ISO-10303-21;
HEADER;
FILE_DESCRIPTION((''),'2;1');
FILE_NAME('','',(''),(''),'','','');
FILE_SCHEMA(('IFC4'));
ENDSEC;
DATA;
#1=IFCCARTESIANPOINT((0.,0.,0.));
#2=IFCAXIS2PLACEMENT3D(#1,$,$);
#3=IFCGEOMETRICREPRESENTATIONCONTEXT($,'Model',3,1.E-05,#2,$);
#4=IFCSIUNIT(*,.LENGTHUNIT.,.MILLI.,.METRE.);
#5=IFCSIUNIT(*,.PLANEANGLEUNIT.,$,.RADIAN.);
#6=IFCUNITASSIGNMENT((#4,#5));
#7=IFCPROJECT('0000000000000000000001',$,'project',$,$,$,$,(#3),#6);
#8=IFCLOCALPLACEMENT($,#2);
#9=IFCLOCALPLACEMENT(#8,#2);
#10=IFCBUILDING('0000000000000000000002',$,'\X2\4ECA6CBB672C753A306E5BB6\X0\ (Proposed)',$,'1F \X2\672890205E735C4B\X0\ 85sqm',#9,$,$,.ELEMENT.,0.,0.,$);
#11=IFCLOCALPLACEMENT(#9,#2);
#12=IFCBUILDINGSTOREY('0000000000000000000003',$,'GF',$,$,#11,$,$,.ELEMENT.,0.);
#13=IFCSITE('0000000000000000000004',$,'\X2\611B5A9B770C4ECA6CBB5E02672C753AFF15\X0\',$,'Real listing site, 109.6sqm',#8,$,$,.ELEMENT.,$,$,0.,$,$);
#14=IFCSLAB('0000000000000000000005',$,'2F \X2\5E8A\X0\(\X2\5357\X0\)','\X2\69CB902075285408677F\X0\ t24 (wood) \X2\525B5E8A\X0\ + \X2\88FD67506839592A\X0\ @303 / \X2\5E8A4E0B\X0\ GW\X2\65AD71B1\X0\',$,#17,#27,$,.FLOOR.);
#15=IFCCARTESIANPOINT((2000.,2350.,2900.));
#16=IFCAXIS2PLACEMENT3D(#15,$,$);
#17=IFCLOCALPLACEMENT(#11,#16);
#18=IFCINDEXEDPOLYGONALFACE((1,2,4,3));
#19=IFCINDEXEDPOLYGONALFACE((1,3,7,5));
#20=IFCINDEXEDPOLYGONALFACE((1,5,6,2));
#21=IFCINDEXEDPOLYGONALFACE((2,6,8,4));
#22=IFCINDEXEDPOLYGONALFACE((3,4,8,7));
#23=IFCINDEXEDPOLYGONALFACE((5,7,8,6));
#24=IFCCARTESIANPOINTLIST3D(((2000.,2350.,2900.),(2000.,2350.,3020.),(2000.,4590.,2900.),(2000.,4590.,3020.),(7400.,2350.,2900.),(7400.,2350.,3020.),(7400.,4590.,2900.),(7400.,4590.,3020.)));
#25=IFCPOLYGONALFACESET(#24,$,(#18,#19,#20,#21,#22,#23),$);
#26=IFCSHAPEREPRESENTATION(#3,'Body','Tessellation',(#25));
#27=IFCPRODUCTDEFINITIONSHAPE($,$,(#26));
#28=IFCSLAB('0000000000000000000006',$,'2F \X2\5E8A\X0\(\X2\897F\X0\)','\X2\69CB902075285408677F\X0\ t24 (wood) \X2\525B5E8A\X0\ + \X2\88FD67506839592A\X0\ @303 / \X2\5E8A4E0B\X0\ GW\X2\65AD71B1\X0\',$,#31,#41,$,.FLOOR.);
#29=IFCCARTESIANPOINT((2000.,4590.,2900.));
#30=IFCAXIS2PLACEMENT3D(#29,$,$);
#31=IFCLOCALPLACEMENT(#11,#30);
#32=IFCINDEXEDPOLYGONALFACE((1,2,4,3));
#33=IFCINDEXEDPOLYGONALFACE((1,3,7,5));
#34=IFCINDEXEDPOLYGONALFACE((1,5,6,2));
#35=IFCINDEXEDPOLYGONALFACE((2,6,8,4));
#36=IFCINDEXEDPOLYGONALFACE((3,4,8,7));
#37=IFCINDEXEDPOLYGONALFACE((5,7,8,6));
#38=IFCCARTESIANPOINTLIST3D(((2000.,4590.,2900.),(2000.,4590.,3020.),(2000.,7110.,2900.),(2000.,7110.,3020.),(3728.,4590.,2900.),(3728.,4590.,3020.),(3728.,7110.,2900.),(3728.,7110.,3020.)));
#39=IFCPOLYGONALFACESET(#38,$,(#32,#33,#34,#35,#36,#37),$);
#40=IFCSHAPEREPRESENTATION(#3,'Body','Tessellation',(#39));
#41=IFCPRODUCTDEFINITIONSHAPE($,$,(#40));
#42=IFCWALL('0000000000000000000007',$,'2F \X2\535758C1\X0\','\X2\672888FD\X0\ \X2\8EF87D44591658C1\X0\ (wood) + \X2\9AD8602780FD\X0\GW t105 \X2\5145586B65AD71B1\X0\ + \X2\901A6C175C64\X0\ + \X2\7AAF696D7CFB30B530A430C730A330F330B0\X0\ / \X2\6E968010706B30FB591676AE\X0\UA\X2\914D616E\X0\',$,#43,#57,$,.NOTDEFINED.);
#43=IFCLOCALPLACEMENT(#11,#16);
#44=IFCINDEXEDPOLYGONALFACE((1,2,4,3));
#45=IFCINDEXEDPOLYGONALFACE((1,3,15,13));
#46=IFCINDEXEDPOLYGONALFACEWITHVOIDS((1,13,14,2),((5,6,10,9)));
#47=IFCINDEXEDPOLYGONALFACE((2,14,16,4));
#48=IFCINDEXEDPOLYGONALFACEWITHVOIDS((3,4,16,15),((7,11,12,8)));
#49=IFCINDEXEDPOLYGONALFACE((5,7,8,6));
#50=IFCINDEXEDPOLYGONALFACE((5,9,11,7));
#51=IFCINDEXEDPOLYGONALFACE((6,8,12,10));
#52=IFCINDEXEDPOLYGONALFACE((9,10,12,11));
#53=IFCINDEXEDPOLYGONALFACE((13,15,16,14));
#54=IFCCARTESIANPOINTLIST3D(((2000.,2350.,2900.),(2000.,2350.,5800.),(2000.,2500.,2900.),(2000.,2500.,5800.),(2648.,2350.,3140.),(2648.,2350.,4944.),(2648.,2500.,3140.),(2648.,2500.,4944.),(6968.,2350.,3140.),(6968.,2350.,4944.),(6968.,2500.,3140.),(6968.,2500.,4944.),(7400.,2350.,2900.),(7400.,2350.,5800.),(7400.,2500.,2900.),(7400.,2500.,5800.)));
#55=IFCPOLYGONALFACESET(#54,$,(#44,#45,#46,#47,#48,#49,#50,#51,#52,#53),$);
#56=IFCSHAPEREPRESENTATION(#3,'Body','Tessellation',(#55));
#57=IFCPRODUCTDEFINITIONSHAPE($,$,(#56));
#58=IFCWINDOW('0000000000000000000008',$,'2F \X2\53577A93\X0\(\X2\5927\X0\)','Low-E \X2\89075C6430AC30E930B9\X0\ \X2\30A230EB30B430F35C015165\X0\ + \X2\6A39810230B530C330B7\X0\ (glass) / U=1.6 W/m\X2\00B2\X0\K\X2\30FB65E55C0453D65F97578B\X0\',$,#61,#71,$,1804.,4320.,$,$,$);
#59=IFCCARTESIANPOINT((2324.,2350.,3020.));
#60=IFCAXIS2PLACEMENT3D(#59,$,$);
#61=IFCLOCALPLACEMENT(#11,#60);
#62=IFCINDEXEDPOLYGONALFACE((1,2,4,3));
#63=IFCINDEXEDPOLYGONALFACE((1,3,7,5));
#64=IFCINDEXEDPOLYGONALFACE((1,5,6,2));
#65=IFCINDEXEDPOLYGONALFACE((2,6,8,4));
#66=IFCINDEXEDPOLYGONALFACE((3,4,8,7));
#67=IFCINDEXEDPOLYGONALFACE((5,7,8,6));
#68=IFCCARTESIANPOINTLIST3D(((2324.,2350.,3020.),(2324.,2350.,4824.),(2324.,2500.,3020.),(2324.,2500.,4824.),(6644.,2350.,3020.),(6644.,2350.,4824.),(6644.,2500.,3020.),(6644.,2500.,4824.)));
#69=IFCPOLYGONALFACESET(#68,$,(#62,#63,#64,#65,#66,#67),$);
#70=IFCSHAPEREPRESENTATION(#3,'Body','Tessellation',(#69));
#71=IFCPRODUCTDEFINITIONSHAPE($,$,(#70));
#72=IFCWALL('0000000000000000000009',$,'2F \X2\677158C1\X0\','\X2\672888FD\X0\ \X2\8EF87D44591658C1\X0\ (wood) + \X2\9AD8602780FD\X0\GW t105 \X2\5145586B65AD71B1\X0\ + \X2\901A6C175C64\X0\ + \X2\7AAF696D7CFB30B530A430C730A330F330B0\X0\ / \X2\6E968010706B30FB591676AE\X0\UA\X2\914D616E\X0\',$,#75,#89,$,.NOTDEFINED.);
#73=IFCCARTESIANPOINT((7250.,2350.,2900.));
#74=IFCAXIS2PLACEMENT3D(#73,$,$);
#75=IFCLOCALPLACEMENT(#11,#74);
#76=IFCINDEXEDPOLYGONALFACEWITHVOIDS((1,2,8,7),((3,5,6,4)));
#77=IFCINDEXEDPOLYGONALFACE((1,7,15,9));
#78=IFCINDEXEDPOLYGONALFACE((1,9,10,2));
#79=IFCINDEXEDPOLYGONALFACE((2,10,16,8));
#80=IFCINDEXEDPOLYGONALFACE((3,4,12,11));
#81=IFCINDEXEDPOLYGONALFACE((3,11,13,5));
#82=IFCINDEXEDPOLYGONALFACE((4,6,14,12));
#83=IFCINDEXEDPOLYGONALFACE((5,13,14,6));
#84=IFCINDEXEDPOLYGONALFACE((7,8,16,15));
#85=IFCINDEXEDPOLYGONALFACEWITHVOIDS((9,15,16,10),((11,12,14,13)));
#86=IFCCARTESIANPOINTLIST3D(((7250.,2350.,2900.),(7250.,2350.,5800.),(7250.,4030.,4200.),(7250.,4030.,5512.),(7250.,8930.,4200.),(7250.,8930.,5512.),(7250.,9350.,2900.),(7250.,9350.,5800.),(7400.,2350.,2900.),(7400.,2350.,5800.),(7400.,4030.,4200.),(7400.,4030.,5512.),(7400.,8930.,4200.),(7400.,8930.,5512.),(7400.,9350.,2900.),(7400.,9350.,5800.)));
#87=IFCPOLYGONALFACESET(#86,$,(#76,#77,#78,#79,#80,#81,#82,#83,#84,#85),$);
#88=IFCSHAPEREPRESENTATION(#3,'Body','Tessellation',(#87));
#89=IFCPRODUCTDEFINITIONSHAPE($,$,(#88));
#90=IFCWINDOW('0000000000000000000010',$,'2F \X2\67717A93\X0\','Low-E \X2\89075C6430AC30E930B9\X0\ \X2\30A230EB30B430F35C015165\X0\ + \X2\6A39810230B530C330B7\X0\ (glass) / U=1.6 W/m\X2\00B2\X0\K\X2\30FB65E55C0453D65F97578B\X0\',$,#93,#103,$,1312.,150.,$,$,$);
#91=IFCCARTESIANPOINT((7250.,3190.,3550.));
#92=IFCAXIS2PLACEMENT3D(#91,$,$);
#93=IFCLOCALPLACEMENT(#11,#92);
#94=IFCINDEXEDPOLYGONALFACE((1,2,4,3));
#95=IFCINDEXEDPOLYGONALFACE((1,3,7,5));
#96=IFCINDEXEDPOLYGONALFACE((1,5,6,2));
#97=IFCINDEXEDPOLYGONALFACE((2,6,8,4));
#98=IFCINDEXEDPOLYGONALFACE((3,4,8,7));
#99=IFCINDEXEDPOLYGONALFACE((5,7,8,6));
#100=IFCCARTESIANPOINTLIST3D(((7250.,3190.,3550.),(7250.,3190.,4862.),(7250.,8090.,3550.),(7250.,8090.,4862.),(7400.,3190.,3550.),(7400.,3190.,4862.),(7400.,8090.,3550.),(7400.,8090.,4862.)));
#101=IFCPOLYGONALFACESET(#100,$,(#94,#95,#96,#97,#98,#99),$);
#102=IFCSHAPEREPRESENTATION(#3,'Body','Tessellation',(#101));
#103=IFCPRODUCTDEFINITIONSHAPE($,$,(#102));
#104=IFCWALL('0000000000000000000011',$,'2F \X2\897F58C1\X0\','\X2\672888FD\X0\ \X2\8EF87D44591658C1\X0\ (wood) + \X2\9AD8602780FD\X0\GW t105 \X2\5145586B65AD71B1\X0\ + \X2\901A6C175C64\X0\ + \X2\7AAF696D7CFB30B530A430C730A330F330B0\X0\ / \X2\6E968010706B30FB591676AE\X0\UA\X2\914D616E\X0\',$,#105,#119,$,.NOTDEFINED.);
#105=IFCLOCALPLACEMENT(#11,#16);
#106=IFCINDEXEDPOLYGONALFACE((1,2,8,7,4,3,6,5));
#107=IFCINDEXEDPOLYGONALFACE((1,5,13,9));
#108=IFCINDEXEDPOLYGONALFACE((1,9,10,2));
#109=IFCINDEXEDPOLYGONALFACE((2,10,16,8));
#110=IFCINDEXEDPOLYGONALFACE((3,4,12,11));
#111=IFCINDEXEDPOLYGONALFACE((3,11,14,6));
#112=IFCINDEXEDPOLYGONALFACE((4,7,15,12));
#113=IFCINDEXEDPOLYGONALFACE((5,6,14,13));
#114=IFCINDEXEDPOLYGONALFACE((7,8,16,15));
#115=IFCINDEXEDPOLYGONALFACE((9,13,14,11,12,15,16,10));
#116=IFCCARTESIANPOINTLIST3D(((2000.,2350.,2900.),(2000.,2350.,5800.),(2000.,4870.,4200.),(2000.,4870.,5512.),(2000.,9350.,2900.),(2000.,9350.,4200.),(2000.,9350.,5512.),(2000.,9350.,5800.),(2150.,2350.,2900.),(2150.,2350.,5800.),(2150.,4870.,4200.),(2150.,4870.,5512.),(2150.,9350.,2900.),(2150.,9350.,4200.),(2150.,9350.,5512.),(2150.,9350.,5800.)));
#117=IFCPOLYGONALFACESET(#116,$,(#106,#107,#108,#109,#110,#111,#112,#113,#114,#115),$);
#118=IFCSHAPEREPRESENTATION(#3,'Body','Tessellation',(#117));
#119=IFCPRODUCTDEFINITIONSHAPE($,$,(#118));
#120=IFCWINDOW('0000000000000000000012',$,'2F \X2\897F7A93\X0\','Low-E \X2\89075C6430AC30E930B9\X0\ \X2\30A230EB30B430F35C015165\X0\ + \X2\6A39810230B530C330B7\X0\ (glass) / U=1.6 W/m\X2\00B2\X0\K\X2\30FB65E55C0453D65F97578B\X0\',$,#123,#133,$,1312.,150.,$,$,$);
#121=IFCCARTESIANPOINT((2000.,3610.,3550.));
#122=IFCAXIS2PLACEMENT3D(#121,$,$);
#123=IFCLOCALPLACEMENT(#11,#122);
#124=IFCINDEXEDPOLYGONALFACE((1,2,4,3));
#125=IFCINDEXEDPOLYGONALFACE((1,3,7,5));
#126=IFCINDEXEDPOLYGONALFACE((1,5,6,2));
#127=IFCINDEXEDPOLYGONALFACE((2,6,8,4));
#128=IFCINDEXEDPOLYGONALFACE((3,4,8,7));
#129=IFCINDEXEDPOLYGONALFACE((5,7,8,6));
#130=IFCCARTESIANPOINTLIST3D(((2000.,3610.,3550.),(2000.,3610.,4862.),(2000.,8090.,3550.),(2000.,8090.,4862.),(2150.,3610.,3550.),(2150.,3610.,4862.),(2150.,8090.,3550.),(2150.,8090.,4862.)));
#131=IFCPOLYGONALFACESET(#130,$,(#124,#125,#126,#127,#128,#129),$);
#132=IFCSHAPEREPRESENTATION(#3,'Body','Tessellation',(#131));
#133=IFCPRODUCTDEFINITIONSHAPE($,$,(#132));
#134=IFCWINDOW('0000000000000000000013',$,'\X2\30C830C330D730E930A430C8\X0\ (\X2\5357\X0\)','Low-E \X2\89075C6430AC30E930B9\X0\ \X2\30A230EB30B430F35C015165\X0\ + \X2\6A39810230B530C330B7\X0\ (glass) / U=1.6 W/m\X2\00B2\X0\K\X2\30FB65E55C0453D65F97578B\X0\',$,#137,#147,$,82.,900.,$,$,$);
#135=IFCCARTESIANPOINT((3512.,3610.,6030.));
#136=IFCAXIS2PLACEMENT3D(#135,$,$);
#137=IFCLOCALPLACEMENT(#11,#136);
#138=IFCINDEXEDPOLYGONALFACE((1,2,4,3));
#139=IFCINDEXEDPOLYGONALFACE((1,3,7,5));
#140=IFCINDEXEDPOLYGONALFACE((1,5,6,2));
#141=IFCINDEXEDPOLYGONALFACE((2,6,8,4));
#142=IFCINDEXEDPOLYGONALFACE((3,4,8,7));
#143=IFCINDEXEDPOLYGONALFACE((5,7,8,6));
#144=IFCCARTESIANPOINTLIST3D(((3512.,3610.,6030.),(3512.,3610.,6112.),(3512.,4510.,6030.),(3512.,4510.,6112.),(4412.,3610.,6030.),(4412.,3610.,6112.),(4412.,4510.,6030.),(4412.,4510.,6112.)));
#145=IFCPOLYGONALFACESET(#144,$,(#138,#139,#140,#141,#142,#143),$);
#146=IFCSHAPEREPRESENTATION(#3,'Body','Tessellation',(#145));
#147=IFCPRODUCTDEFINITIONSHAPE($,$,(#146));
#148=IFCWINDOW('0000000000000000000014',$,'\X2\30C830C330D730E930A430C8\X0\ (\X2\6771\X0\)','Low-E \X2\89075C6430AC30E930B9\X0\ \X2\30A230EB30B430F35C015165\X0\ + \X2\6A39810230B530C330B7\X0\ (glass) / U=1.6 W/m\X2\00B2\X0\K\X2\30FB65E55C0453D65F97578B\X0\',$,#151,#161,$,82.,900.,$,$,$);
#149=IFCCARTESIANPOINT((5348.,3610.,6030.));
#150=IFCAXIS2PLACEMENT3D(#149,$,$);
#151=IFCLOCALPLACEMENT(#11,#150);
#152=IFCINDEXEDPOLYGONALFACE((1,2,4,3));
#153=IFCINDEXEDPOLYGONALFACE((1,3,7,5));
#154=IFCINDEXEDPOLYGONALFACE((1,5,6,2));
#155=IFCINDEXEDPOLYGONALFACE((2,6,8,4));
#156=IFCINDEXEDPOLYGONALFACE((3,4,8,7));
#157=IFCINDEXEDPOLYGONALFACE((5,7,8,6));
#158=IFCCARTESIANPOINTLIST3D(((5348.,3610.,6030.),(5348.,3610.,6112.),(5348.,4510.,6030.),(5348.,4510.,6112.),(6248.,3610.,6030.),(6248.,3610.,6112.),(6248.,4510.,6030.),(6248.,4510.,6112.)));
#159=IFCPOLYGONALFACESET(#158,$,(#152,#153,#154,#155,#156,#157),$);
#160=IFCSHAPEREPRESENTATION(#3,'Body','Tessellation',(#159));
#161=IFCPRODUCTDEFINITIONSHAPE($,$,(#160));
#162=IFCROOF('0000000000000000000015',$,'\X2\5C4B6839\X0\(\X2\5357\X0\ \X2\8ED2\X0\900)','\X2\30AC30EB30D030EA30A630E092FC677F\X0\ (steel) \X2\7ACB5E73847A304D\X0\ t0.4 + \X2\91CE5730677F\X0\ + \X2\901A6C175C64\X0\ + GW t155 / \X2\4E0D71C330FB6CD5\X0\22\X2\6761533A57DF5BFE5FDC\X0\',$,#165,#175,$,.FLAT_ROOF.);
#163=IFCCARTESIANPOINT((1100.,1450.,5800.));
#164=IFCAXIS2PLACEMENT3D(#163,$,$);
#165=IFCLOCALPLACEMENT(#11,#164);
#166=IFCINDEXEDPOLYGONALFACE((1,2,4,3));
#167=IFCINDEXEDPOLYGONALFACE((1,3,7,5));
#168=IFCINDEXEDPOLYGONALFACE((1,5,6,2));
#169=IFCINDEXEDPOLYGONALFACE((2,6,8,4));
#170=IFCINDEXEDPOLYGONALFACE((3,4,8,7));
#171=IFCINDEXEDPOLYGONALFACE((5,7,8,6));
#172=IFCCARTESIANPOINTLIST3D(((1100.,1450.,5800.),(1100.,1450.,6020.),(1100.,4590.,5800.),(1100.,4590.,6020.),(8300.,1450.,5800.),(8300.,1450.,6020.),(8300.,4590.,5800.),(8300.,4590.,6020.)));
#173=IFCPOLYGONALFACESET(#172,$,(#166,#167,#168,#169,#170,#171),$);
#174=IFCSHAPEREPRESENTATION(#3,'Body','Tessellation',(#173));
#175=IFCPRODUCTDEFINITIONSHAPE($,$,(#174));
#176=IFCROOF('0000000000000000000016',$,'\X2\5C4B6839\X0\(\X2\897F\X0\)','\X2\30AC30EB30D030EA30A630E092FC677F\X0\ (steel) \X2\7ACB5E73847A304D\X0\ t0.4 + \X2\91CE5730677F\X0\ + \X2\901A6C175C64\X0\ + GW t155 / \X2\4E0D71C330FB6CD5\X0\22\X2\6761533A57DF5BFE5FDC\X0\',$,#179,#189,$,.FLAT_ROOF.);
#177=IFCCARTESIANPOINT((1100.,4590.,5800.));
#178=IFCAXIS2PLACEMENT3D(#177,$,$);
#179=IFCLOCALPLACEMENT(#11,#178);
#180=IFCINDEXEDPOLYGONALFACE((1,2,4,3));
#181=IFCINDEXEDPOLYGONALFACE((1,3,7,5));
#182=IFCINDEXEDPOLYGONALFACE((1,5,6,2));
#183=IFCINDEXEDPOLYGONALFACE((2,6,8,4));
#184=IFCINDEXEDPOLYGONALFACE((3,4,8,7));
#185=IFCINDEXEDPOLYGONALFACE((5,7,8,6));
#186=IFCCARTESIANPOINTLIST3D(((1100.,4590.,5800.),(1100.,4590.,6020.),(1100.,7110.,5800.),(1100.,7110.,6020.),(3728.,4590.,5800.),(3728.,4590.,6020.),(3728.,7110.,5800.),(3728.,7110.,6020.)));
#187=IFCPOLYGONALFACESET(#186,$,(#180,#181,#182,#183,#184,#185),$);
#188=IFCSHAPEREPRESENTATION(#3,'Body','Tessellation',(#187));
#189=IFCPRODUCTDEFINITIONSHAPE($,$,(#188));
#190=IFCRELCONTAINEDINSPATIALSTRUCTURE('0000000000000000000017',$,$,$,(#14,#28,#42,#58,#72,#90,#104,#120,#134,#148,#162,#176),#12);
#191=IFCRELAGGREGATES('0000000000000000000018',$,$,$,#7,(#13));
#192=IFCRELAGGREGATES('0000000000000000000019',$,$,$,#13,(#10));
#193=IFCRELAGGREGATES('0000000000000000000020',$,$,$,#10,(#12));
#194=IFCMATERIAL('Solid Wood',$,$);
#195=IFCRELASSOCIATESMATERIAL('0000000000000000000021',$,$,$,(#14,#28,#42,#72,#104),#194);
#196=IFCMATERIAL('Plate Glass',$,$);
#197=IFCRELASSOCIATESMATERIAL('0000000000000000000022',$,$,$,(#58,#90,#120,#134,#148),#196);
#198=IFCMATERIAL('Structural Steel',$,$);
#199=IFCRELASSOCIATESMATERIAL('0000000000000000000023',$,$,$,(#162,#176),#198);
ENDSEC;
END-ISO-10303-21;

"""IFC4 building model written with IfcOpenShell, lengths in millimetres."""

from ifc_helpers import new_model, si_unit, frame, frame_2d, origin, place, context, project, spatial, rectangle, extrude, material, element, fill, save


model = new_model("IFC4")

# Units and contexts
model_context = context("Model", 3, precision=1e-05, world=origin())
ifc_project = project(units=[si_unit("LENGTHUNIT", "METRE", prefix="MILLI"), si_unit("PLANEANGLEUNIT", "RADIAN")], contexts=[model_context])

# Site, building, storey
site_placement = place(None, origin())
site = spatial("IfcSite", under=ifc_project, at=site_placement, Name="愛媛県今治市本町５", ObjectType="Real listing site, 109.6sqm", CompositionType="ELEMENT", RefElevation=0.0)
building_placement = place(site_placement, origin())
building = spatial("IfcBuilding", under=site, at=building_placement, Name="今治本町の家 (Proposed)", ObjectType="1F 木造平屋 85sqm", CompositionType="ELEMENT", ElevationOfRefHeight=0.0, ElevationOfTerrain=0.0)
storey_placement = place(building_placement, origin())
storey = spatial("IfcBuildingStorey", under=building, at=storey_placement, Name="GF", CompositionType="ELEMENT", Elevation=0.0)

# Slabs
ifc_material_1 = material(Name="Solid Wood")
slab_1_placement = place(storey_placement, frame((2000.0, 2350.0, 2900.0)))
element("IfcSlab", 1, at=slab_1_placement, inside=storey, material=ifc_material_1, Name="2F 床(南)", Description="構造用合板 t24 (wood) 剛床 + 製材根太 @303 / 床下 GW断熱", PredefinedType="FLOOR", context=model_context, shape_type="SweptSolid", body=[
    extrude(rectangle(XDim=5400.0, YDim=2240.0, at=frame_2d((2700.0, 1120.0))), frame((2000.0, 2350.0, 2900.0)), (0.0, 0.0, 1.0), 120.0),
])
slab_2_placement = place(storey_placement, frame((2000.0, 4590.0, 2900.0)))
element("IfcSlab", 2, at=slab_2_placement, inside=storey, material=ifc_material_1, Name="2F 床(西)", Description="構造用合板 t24 (wood) 剛床 + 製材根太 @303 / 床下 GW断熱", PredefinedType="FLOOR", context=model_context, shape_type="SweptSolid", body=[
    extrude(rectangle(XDim=1728.0, YDim=2520.0, at=frame_2d((864.0, 1260.0))), frame((2000.0, 4590.0, 2900.0)), (0.0, 0.0, 1.0), 120.0),
])

# Walls, openings, windows
wall_1_placement = place(storey_placement, frame((2000.0, 2350.0, 2900.0)))
wall_1 = element("IfcWall", 3, at=wall_1_placement, inside=storey, material=ifc_material_1, Name="2F 南壁", Description="木製 軸組外壁 (wood) + 高性能GW t105 充填断熱 + 通気層 + 窯業系サイディング / 準耐火・外皮UA配慮", PredefinedType="NOTDEFINED", context=model_context, shape_type="SweptSolid", body=[
    extrude(rectangle(XDim=5400.0, YDim=150.0, at=frame_2d((2700.0, 75.0))), frame((2000.0, 2350.0, 2900.0)), (0.0, 0.0, 1.0), 2900.0),
])
opening_1_placement = place(storey_placement, frame((2324.0, 2350.0, 3020.0)))
opening_1 = element("IfcOpeningElement", 4, at=opening_1_placement, cuts=wall_1, PredefinedType="NOTDEFINED", context=model_context, shape_type="SweptSolid", body=[
    extrude(rectangle(XDim=4320.0, YDim=150.0, at=frame_2d((2160.0, 75.0))), frame((2324.0, 2350.0, 3020.0)), (0.0, 0.0, 1.0), 1804.0),
])
ifc_material_2 = material(Name="Plate Glass")
window_1_placement = place(storey_placement, frame((2324.0, 2350.0, 3020.0)))
window_1 = element("IfcWindow", 5, at=window_1_placement, inside=storey, material=ifc_material_2, Name="2F 南窓(大)", Description="Low-E 複層ガラス アルゴン封入 + 樹脂サッシ (glass) / U=1.6 W/m²K・日射取得型", OverallHeight=1804.0, OverallWidth=4320.0, context=model_context, shape_type="SweptSolid", body=[
    extrude(rectangle(XDim=4320.0, YDim=150.0, at=frame_2d((2160.0, 75.0))), frame((2324.0, 2350.0, 3020.0)), (0.0, 0.0, 1.0), 1804.0),
])
fill(opening_1, window_1)
wall_2_placement = place(storey_placement, frame((7250.0, 2350.0, 2900.0)))
wall_2 = element("IfcWall", 6, at=wall_2_placement, inside=storey, material=ifc_material_1, Name="2F 東壁", Description="木製 軸組外壁 (wood) + 高性能GW t105 充填断熱 + 通気層 + 窯業系サイディング / 準耐火・外皮UA配慮", PredefinedType="NOTDEFINED", context=model_context, shape_type="SweptSolid", body=[
    extrude(rectangle(XDim=150.0, YDim=7000.0, at=frame_2d((75.0, 3500.0))), frame((7250.0, 2350.0, 2900.0)), (0.0, 0.0, 1.0), 2900.0),
])
opening_2_placement = place(storey_placement, frame((7250.0, 3190.0, 3550.0)))
opening_2 = element("IfcOpeningElement", 7, at=opening_2_placement, cuts=wall_2, PredefinedType="NOTDEFINED", context=model_context, shape_type="SweptSolid", body=[
    extrude(rectangle(XDim=150.0, YDim=4900.0, at=frame_2d((75.0, 2450.0))), frame((7250.0, 3190.0, 3550.0)), (0.0, 0.0, 1.0), 1312.0),
])
window_2_placement = place(storey_placement, frame((7250.0, 3190.0, 3550.0)))
window_2 = element("IfcWindow", 8, at=window_2_placement, inside=storey, material=ifc_material_2, Name="2F 東窓", Description="Low-E 複層ガラス アルゴン封入 + 樹脂サッシ (glass) / U=1.6 W/m²K・日射取得型", OverallHeight=1312.0, OverallWidth=150.0, context=model_context, shape_type="SweptSolid", body=[
    extrude(rectangle(XDim=150.0, YDim=4900.0, at=frame_2d((75.0, 2450.0))), frame((7250.0, 3190.0, 3550.0)), (0.0, 0.0, 1.0), 1312.0),
])
fill(opening_2, window_2)
wall_3_placement = place(storey_placement, frame((2000.0, 2350.0, 2900.0)))
wall_3 = element("IfcWall", 9, at=wall_3_placement, inside=storey, material=ifc_material_1, Name="2F 西壁", Description="木製 軸組外壁 (wood) + 高性能GW t105 充填断熱 + 通気層 + 窯業系サイディング / 準耐火・外皮UA配慮", PredefinedType="NOTDEFINED", context=model_context, shape_type="SweptSolid", body=[
    extrude(rectangle(XDim=150.0, YDim=7000.0, at=frame_2d((75.0, 3500.0))), frame((2000.0, 2350.0, 2900.0)), (0.0, 0.0, 1.0), 2900.0),
])
opening_3_placement = place(storey_placement, frame((2000.0, 3610.0, 3550.0)))
opening_3 = element("IfcOpeningElement", 10, at=opening_3_placement, cuts=wall_3, PredefinedType="NOTDEFINED", context=model_context, shape_type="SweptSolid", body=[
    extrude(rectangle(XDim=150.0, YDim=4480.0, at=frame_2d((75.0, 2240.0))), frame((2000.0, 3610.0, 3550.0)), (0.0, 0.0, 1.0), 1312.0),
])
window_3_placement = place(storey_placement, frame((2000.0, 3610.0, 3550.0)))
window_3 = element("IfcWindow", 11, at=window_3_placement, inside=storey, material=ifc_material_2, Name="2F 西窓", Description="Low-E 複層ガラス アルゴン封入 + 樹脂サッシ (glass) / U=1.6 W/m²K・日射取得型", OverallHeight=1312.0, OverallWidth=150.0, context=model_context, shape_type="SweptSolid", body=[
    extrude(rectangle(XDim=150.0, YDim=4480.0, at=frame_2d((75.0, 2240.0))), frame((2000.0, 3610.0, 3550.0)), (0.0, 0.0, 1.0), 1312.0),
])
fill(opening_3, window_3)

# Windows
window_4_placement = place(storey_placement, frame((3512.0, 3610.0, 6030.0)))
element("IfcWindow", 12, at=window_4_placement, inside=storey, material=ifc_material_2, Name="トップライト (南)", Description="Low-E 複層ガラス アルゴン封入 + 樹脂サッシ (glass) / U=1.6 W/m²K・日射取得型", OverallHeight=82.0, OverallWidth=900.0, context=model_context, shape_type="SweptSolid", body=[
    extrude(rectangle(XDim=900.0, YDim=900.0, at=frame_2d((450.0, 450.0))), frame((3512.0, 3610.0, 6030.0)), (0.0, 0.0, 1.0), 82.0),
])
window_5_placement = place(storey_placement, frame((5348.0, 3610.0, 6030.0)))
element("IfcWindow", 13, at=window_5_placement, inside=storey, material=ifc_material_2, Name="トップライト (東)", Description="Low-E 複層ガラス アルゴン封入 + 樹脂サッシ (glass) / U=1.6 W/m²K・日射取得型", OverallHeight=82.0, OverallWidth=900.0, context=model_context, shape_type="SweptSolid", body=[
    extrude(rectangle(XDim=900.0, YDim=900.0, at=frame_2d((450.0, 450.0))), frame((5348.0, 3610.0, 6030.0)), (0.0, 0.0, 1.0), 82.0),
])

# Roofs
ifc_material_3 = material(Name="Structural Steel")
roof_1_placement = place(storey_placement, frame((1100.0, 1450.0, 5800.0)))
element("IfcRoof", 14, at=roof_1_placement, inside=storey, material=ifc_material_3, Name="屋根(南 軒900)", Description="ガルバリウム鋼板 (steel) 立平葺き t0.4 + 野地板 + 通気層 + GW t155 / 不燃・法22条区域対応", PredefinedType="FLAT_ROOF", context=model_context, shape_type="SweptSolid", body=[
    extrude(rectangle(XDim=7200.0, YDim=3140.0, at=frame_2d((3600.0, 1570.0))), frame((1100.0, 1450.0, 5800.0)), (0.0, 0.0, 1.0), 220.0),
])
roof_2_placement = place(storey_placement, frame((1100.0, 4590.0, 5800.0)))
element("IfcRoof", 15, at=roof_2_placement, inside=storey, material=ifc_material_3, Name="屋根(西)", Description="ガルバリウム鋼板 (steel) 立平葺き t0.4 + 野地板 + 通気層 + GW t155 / 不燃・法22条区域対応", PredefinedType="FLAT_ROOF", context=model_context, shape_type="SweptSolid", body=[
    extrude(rectangle(XDim=2628.0, YDim=2520.0, at=frame_2d((1314.0, 1260.0))), frame((1100.0, 4590.0, 5800.0)), (0.0, 0.0, 1.0), 220.0),
])

save(model, "model.ifc")
